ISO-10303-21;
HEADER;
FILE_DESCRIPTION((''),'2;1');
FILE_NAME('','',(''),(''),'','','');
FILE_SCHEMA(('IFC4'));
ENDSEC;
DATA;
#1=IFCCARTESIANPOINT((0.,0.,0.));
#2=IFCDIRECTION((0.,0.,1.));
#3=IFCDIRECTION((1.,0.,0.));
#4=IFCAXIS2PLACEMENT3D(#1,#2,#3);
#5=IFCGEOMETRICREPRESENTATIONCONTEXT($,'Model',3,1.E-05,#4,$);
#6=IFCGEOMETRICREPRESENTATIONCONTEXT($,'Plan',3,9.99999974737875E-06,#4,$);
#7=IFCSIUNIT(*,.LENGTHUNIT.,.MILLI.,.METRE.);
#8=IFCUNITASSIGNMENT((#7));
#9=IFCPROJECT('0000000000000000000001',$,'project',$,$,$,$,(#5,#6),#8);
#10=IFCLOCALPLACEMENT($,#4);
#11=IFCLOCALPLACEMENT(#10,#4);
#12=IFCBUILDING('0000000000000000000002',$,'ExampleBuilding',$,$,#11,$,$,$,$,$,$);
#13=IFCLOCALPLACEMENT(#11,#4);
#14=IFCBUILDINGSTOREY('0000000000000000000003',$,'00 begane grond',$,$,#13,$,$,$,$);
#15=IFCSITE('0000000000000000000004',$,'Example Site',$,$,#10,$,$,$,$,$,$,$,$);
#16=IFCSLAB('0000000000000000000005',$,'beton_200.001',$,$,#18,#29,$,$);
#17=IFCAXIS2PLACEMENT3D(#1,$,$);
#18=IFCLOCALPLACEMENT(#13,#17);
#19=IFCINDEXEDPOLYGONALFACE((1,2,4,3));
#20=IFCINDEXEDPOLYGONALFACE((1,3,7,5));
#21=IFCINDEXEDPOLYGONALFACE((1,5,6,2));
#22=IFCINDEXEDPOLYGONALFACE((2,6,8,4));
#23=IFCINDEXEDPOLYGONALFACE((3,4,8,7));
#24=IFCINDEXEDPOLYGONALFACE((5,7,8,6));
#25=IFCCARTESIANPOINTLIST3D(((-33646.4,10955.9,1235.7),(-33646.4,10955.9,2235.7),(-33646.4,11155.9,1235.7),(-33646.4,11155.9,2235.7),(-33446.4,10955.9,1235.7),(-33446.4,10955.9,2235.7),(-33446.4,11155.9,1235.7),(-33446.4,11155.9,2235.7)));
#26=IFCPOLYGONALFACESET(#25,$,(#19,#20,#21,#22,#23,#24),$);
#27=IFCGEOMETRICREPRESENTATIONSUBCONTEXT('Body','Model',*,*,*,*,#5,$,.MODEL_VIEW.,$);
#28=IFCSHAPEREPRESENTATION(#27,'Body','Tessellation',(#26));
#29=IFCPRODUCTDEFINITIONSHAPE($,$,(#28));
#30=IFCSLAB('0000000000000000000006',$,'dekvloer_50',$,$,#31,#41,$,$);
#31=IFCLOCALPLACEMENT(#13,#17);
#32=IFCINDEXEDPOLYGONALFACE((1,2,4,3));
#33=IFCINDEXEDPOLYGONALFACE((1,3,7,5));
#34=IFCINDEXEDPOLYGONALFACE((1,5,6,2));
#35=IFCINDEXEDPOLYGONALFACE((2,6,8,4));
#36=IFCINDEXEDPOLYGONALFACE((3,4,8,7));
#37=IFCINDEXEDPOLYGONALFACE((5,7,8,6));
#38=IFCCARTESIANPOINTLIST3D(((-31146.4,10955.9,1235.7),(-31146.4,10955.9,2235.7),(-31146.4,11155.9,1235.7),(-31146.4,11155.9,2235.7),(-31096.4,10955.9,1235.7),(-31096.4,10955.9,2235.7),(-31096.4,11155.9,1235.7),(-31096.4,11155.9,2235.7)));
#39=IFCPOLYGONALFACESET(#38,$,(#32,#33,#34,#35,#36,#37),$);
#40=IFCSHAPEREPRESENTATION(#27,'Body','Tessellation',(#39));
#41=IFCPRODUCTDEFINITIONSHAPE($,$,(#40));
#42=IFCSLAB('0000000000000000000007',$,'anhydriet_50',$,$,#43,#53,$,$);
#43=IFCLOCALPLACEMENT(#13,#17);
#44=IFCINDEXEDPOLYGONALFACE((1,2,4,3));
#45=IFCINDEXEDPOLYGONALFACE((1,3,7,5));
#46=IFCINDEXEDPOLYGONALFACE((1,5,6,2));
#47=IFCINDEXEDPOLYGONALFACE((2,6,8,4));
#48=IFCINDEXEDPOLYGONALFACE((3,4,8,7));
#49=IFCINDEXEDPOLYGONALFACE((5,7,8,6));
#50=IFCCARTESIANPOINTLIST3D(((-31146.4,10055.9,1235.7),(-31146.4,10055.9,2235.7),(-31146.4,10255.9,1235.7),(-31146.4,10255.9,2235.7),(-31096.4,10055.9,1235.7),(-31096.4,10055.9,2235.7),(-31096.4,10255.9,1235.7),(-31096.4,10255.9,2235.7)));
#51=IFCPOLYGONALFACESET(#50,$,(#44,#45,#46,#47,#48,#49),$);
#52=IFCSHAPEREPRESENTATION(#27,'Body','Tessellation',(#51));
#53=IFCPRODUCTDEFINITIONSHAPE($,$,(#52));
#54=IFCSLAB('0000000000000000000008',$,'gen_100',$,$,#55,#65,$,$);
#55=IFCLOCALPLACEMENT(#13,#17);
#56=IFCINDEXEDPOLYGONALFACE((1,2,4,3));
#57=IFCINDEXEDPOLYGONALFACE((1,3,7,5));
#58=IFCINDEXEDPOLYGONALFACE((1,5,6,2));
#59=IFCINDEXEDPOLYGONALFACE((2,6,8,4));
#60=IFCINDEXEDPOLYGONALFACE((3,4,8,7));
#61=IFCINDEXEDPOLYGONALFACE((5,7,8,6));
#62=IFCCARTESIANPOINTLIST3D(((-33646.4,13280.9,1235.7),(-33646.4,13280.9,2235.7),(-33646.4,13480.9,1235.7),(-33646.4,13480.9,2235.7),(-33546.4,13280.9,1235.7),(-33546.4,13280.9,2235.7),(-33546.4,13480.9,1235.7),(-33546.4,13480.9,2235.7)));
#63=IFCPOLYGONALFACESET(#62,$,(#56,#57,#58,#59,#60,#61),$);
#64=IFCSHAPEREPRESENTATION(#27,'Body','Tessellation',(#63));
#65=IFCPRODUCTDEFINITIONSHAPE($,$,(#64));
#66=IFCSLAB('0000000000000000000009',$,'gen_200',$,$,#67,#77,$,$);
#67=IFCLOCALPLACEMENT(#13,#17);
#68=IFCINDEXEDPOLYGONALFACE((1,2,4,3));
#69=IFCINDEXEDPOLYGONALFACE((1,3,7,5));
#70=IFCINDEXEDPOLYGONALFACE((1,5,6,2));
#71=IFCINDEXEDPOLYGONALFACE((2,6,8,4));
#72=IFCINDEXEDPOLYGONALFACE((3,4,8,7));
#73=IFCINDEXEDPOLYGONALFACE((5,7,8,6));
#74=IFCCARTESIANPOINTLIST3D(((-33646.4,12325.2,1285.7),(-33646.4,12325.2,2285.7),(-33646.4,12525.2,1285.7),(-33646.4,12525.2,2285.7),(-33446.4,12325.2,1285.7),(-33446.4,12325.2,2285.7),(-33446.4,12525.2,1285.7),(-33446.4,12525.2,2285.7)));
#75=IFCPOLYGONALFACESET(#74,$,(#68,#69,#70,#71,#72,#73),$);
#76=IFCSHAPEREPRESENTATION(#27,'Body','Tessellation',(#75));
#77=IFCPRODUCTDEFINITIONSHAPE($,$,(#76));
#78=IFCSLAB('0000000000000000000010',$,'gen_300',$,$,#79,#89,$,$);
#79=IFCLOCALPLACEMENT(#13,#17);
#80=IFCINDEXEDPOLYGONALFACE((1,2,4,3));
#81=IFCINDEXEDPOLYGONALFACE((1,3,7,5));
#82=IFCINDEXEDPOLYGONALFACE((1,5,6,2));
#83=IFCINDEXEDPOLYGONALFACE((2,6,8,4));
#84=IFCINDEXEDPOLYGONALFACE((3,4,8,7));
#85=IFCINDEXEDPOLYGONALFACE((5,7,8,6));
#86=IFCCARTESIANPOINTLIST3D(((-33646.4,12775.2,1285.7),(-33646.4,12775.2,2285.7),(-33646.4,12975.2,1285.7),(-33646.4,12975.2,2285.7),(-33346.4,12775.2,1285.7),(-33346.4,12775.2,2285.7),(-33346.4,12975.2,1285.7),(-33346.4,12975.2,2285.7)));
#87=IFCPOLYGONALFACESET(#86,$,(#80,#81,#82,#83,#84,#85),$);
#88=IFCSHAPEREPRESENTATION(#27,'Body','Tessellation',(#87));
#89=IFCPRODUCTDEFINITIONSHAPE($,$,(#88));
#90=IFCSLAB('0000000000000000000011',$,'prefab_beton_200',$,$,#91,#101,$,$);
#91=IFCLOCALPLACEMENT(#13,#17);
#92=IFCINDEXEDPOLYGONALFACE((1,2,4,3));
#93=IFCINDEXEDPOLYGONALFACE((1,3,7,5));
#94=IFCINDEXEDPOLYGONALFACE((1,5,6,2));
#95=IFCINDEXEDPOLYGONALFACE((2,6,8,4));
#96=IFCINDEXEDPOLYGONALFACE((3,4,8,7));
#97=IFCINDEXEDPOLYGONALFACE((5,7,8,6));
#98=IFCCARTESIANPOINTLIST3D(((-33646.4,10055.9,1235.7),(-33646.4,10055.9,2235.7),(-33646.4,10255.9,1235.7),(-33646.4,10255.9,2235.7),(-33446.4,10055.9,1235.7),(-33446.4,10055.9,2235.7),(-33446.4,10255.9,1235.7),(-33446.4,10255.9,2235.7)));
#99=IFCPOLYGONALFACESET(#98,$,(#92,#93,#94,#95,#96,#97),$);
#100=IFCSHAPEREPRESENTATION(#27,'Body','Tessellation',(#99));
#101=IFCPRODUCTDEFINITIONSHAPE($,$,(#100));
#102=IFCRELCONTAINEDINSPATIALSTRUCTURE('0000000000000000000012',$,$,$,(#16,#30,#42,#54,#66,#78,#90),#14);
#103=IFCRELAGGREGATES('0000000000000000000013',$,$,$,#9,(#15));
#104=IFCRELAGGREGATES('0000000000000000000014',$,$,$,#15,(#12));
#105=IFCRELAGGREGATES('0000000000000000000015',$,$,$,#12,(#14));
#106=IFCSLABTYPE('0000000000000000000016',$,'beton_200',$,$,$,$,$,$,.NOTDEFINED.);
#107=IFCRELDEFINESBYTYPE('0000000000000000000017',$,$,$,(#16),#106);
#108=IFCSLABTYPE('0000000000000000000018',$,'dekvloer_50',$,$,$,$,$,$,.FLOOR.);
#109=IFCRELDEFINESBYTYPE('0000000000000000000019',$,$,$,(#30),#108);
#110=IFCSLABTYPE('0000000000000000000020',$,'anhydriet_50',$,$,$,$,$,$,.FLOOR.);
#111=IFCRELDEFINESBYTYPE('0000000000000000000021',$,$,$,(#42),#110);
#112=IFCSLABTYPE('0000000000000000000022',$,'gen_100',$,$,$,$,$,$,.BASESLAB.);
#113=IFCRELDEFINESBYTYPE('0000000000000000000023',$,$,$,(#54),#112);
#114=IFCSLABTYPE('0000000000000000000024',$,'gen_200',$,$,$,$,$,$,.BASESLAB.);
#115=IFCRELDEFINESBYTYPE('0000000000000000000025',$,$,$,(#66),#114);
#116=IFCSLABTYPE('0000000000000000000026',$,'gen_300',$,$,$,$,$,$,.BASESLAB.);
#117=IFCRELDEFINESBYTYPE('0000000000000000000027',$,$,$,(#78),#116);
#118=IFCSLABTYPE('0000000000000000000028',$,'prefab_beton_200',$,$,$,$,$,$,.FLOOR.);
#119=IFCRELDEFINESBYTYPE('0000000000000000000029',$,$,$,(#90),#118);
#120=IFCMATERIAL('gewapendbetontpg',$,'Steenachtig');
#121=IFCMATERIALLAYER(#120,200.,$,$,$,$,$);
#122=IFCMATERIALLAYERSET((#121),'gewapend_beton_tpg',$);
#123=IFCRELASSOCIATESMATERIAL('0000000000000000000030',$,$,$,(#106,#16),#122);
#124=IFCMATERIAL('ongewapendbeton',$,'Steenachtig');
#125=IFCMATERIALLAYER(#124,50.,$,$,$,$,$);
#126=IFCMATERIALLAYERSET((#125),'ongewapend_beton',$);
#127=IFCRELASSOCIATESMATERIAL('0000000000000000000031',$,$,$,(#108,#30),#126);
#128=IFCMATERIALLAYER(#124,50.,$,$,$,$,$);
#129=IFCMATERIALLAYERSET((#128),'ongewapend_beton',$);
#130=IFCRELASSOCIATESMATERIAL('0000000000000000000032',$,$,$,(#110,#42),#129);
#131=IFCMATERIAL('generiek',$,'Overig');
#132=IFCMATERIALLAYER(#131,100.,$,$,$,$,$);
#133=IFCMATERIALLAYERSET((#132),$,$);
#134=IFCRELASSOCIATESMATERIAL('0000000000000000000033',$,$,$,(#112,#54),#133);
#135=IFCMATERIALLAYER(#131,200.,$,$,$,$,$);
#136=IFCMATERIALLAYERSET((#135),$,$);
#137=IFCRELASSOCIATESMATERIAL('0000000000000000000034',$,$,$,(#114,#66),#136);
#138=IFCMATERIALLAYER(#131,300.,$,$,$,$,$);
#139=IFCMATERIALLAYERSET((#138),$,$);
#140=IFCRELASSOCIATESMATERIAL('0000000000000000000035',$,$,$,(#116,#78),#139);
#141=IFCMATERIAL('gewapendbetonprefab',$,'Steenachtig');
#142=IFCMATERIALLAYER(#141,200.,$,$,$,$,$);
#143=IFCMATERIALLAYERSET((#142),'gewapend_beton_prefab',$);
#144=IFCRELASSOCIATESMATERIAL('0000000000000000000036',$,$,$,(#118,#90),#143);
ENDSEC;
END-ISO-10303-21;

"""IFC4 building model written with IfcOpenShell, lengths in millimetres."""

from ifc_helpers import new_model, si_unit, frame, origin_with_axes, place, context, subcontext, project, spatial, polyline, line, indexed_curve, outline, extrude, material, layer, layer_set, layer_usage, type_object, element, save


model = new_model("IFC4")

# Units and contexts
model_context = context("Model", 3, precision=1e-05, world=origin_with_axes())
plan_context = context("Plan", 3, precision=9.99999974737875e-06, world=origin_with_axes())
body_context = subcontext(model_context, "Body", "Model", "MODEL_VIEW")
ifc_project = project(units=[si_unit("LENGTHUNIT", "METRE", prefix="MILLI")], contexts=[model_context, plan_context])

# Site, building, storey
site_placement = place(None, frame((0.0, 0.0, 0.0), z_axis=(0.0, 0.0, 1.0), x_axis=(1.0, 0.0, 0.0)))
site = spatial("IfcSite", under=ifc_project, at=site_placement, Name="Example Site")
building_placement = place(site_placement, frame((0.0, 0.0, 0.0), z_axis=(0.0, 0.0, 1.0), x_axis=(1.0, 0.0, 0.0)))
building = spatial("IfcBuilding", under=site, at=building_placement, Name="ExampleBuilding")
storey_placement = place(building_placement, frame((0.0, 0.0, 0.0), z_axis=(0.0, 0.0, 1.0), x_axis=(1.0, 0.0, 0.0)))
storey = spatial("IfcBuildingStorey", under=building, at=storey_placement, Name="00 begane grond")

# Shared definitions
ifc_material_1 = material(Name="gewapendbetontpg", Category="Steenachtig")

# Slabs
ifc_material_2 = material(Name="gewapendbetonprefab", Category="Steenachtig")
ifc_layer_1 = layer(ifc_material_1, 200.0)
ifc_layer_set_1 = layer_set([ifc_layer_1], Name="gewapend_beton_tpg")
ifc_layer_usage_1 = layer_usage(ifc_layer_set_1, "AXIS3", "POSITIVE", 0.0)
slab_type_1 = type_object("IfcSlabType", Name="beton_200", PredefinedType="NOTDEFINED", material=ifc_layer_set_1)
slab_1_placement = place(storey_placement, frame((-33646.4, 10955.9, 2235.7), z_axis=(1.0, 0.0, 0.0), x_axis=(0.0, 0.0, -1.0)))
element("IfcSlab", 1, at=slab_1_placement, inside=storey, type_object=slab_type_1, material=ifc_layer_usage_1, Name="beton_200.001", context=body_context, shape_type="SweptSolid", body=[
    extrude(outline(indexed_curve([(1000.0, 200.0), (1000.0, 0.0), (0.0, 0.0), (0.0, 200.0)], segments=[line(3, 2), line(2, 1), line(1, 4), line(4, 3)], self_intersect=False)), None, (0.0, 0.0, 1.0), 200.0),
])
ifc_material_3 = material(Name="ongewapendbeton", Category="Steenachtig")
ifc_layer_2 = layer(ifc_material_3, 50.0)
ifc_layer_set_2 = layer_set([ifc_layer_2], Name="ongewapend_beton")
ifc_layer_usage_2 = layer_usage(ifc_layer_set_2, "AXIS3", "POSITIVE", 0.0)
slab_type_2 = type_object("IfcSlabType", Name="dekvloer_50", PredefinedType="FLOOR", material=ifc_layer_set_2)
slab_2_placement = place(storey_placement, frame((-31146.4, 10955.9, 2235.7), z_axis=(1.0, 0.0, 0.0), x_axis=(0.0, 0.0, -1.0)))
element("IfcSlab", 2, at=slab_2_placement, inside=storey, type_object=slab_type_2, material=ifc_layer_usage_2, Name="dekvloer_50", context=body_context, shape_type="SweptSolid", body=[
    extrude(outline(indexed_curve([(1000.0, 200.0), (1000.0, 0.0), (0.0, 0.0), (0.0, 200.0)], segments=[line(3, 2), line(2, 1), line(1, 4), line(4, 3)], self_intersect=False)), None, (0.0, 0.0, 1.0), 50.0),
])
ifc_layer_3 = layer(ifc_material_3, 50.0)
ifc_layer_set_3 = layer_set([ifc_layer_3], Name="ongewapend_beton")
ifc_layer_usage_3 = layer_usage(ifc_layer_set_3, "AXIS3", "POSITIVE", 0.0)
slab_type_3 = type_object("IfcSlabType", Name="anhydriet_50", PredefinedType="FLOOR", material=ifc_layer_set_3)
slab_3_placement = place(storey_placement, frame((-31146.4, 10055.9, 2235.7), z_axis=(1.0, 0.0, 0.0), x_axis=(0.0, 0.0, -1.0)))
element("IfcSlab", 3, at=slab_3_placement, inside=storey, type_object=slab_type_3, material=ifc_layer_usage_3, Name="anhydriet_50", context=body_context, shape_type="SweptSolid", body=[
    extrude(outline(indexed_curve([(1000.0, 200.0), (1000.0, 0.0), (0.0, 0.0), (0.0, 200.0)], segments=[line(4, 1), line(1, 2), line(2, 3), line(3, 4)], self_intersect=False)), None, (0.0, 0.0, 1.0), 50.0),
])
ifc_material_4 = material(Name="generiek", Category="Overig")
ifc_layer_4 = layer(ifc_material_4, 100.0)
ifc_layer_set_4 = layer_set([ifc_layer_4])
ifc_layer_usage_4 = layer_usage(ifc_layer_set_4, "AXIS3", "POSITIVE", 0.0)
slab_type_4 = type_object("IfcSlabType", Name="gen_100", PredefinedType="BASESLAB", material=ifc_layer_set_4)
slab_4_placement = place(storey_placement, frame((-33646.4, 13280.9, 2235.7), z_axis=(1.0, 0.0, 0.0), x_axis=(0.0, 0.0, -1.0)))
element("IfcSlab", 4, at=slab_4_placement, inside=storey, type_object=slab_type_4, material=ifc_layer_usage_4, Name="gen_100", context=body_context, shape_type="SweptSolid", body=[
    extrude(outline(indexed_curve([(1000.0, 200.0), (1000.0, 0.0), (0.0, 0.0), (0.0, 200.0)], segments=[line(3, 2), line(2, 1), line(1, 4), line(4, 3)], self_intersect=False)), None, (0.0, 0.0, 1.0), 100.0),
])
ifc_layer_5 = layer(ifc_material_4, 200.0)
ifc_layer_set_5 = layer_set([ifc_layer_5])
ifc_layer_usage_5 = layer_usage(ifc_layer_set_5, "AXIS3", "POSITIVE", 0.0)
slab_type_5 = type_object("IfcSlabType", Name="gen_200", PredefinedType="BASESLAB", material=ifc_layer_set_5)
slab_5_placement = place(storey_placement, frame((-33646.4, 12425.2, 1785.7), z_axis=(-1.0, 0.0, 0.0), x_axis=(0.0, 0.0, -1.0)))
element("IfcSlab", 5, at=slab_5_placement, inside=storey, type_object=slab_type_5, material=ifc_layer_usage_5, Name="gen_200", context=body_context, shape_type="SweptSolid", body=[
    extrude(outline(polyline([(-100.0, -500.0), (100.0, -500.0), (100.0, 500.0), (-100.0, 500.0), (-100.0, -500.0)])), frame((0.0, 0.0, 0.0), z_axis=(0.0, 0.0, -1.0), x_axis=(0.0, -1.0, 0.0)), (0.0, 0.0, 1.0), 200.0),
])
ifc_layer_6 = layer(ifc_material_4, 300.0)
ifc_layer_set_6 = layer_set([ifc_layer_6])
ifc_layer_usage_6 = layer_usage(ifc_layer_set_6, "AXIS3", "POSITIVE", 0.0)
slab_type_6 = type_object("IfcSlabType", Name="gen_300", PredefinedType="BASESLAB", material=ifc_layer_set_6)
slab_6_placement = place(storey_placement, frame((-33646.4, 12875.2, 1785.7), z_axis=(-1.0, 0.0, 0.0), x_axis=(0.0, 0.0, -1.0)))
element("IfcSlab", 6, at=slab_6_placement, inside=storey, type_object=slab_type_6, material=ifc_layer_usage_6, Name="gen_300", context=body_context, shape_type="SweptSolid", body=[
    extrude(outline(polyline([(-100.0, -500.0), (100.0, -500.0), (100.0, 500.0), (-100.0, 500.0), (-100.0, -500.0)])), frame((0.0, 0.0, 0.0), z_axis=(0.0, 0.0, -1.0), x_axis=(0.0, -1.0, 0.0)), (0.0, 0.0, 1.0), 300.0),
])
ifc_layer_7 = layer(ifc_material_2, 200.0)
ifc_layer_set_7 = layer_set([ifc_layer_7], Name="gewapend_beton_prefab")
ifc_layer_usage_7 = layer_usage(ifc_layer_set_7, "AXIS3", "POSITIVE", 0.0)
slab_type_7 = type_object("IfcSlabType", Name="prefab_beton_200", PredefinedType="FLOOR", material=ifc_layer_set_7)
slab_7_placement = place(storey_placement, frame((-33646.4, 10055.9, 2235.7), z_axis=(1.0, 0.0, 0.0), x_axis=(0.0, 0.0, -1.0)))
element("IfcSlab", 7, at=slab_7_placement, inside=storey, type_object=slab_type_7, material=ifc_layer_usage_7, Name="prefab_beton_200", context=body_context, shape_type="SweptSolid", body=[
    extrude(outline(indexed_curve([(1000.0, 200.0), (1000.0, 0.0), (0.0, 0.0), (0.0, 200.0)], segments=[line(4, 1), line(1, 2), line(2, 3), line(3, 4)], self_intersect=False)), None, (0.0, 0.0, 1.0), 200.0),
])

save(model, "model.ifc")
